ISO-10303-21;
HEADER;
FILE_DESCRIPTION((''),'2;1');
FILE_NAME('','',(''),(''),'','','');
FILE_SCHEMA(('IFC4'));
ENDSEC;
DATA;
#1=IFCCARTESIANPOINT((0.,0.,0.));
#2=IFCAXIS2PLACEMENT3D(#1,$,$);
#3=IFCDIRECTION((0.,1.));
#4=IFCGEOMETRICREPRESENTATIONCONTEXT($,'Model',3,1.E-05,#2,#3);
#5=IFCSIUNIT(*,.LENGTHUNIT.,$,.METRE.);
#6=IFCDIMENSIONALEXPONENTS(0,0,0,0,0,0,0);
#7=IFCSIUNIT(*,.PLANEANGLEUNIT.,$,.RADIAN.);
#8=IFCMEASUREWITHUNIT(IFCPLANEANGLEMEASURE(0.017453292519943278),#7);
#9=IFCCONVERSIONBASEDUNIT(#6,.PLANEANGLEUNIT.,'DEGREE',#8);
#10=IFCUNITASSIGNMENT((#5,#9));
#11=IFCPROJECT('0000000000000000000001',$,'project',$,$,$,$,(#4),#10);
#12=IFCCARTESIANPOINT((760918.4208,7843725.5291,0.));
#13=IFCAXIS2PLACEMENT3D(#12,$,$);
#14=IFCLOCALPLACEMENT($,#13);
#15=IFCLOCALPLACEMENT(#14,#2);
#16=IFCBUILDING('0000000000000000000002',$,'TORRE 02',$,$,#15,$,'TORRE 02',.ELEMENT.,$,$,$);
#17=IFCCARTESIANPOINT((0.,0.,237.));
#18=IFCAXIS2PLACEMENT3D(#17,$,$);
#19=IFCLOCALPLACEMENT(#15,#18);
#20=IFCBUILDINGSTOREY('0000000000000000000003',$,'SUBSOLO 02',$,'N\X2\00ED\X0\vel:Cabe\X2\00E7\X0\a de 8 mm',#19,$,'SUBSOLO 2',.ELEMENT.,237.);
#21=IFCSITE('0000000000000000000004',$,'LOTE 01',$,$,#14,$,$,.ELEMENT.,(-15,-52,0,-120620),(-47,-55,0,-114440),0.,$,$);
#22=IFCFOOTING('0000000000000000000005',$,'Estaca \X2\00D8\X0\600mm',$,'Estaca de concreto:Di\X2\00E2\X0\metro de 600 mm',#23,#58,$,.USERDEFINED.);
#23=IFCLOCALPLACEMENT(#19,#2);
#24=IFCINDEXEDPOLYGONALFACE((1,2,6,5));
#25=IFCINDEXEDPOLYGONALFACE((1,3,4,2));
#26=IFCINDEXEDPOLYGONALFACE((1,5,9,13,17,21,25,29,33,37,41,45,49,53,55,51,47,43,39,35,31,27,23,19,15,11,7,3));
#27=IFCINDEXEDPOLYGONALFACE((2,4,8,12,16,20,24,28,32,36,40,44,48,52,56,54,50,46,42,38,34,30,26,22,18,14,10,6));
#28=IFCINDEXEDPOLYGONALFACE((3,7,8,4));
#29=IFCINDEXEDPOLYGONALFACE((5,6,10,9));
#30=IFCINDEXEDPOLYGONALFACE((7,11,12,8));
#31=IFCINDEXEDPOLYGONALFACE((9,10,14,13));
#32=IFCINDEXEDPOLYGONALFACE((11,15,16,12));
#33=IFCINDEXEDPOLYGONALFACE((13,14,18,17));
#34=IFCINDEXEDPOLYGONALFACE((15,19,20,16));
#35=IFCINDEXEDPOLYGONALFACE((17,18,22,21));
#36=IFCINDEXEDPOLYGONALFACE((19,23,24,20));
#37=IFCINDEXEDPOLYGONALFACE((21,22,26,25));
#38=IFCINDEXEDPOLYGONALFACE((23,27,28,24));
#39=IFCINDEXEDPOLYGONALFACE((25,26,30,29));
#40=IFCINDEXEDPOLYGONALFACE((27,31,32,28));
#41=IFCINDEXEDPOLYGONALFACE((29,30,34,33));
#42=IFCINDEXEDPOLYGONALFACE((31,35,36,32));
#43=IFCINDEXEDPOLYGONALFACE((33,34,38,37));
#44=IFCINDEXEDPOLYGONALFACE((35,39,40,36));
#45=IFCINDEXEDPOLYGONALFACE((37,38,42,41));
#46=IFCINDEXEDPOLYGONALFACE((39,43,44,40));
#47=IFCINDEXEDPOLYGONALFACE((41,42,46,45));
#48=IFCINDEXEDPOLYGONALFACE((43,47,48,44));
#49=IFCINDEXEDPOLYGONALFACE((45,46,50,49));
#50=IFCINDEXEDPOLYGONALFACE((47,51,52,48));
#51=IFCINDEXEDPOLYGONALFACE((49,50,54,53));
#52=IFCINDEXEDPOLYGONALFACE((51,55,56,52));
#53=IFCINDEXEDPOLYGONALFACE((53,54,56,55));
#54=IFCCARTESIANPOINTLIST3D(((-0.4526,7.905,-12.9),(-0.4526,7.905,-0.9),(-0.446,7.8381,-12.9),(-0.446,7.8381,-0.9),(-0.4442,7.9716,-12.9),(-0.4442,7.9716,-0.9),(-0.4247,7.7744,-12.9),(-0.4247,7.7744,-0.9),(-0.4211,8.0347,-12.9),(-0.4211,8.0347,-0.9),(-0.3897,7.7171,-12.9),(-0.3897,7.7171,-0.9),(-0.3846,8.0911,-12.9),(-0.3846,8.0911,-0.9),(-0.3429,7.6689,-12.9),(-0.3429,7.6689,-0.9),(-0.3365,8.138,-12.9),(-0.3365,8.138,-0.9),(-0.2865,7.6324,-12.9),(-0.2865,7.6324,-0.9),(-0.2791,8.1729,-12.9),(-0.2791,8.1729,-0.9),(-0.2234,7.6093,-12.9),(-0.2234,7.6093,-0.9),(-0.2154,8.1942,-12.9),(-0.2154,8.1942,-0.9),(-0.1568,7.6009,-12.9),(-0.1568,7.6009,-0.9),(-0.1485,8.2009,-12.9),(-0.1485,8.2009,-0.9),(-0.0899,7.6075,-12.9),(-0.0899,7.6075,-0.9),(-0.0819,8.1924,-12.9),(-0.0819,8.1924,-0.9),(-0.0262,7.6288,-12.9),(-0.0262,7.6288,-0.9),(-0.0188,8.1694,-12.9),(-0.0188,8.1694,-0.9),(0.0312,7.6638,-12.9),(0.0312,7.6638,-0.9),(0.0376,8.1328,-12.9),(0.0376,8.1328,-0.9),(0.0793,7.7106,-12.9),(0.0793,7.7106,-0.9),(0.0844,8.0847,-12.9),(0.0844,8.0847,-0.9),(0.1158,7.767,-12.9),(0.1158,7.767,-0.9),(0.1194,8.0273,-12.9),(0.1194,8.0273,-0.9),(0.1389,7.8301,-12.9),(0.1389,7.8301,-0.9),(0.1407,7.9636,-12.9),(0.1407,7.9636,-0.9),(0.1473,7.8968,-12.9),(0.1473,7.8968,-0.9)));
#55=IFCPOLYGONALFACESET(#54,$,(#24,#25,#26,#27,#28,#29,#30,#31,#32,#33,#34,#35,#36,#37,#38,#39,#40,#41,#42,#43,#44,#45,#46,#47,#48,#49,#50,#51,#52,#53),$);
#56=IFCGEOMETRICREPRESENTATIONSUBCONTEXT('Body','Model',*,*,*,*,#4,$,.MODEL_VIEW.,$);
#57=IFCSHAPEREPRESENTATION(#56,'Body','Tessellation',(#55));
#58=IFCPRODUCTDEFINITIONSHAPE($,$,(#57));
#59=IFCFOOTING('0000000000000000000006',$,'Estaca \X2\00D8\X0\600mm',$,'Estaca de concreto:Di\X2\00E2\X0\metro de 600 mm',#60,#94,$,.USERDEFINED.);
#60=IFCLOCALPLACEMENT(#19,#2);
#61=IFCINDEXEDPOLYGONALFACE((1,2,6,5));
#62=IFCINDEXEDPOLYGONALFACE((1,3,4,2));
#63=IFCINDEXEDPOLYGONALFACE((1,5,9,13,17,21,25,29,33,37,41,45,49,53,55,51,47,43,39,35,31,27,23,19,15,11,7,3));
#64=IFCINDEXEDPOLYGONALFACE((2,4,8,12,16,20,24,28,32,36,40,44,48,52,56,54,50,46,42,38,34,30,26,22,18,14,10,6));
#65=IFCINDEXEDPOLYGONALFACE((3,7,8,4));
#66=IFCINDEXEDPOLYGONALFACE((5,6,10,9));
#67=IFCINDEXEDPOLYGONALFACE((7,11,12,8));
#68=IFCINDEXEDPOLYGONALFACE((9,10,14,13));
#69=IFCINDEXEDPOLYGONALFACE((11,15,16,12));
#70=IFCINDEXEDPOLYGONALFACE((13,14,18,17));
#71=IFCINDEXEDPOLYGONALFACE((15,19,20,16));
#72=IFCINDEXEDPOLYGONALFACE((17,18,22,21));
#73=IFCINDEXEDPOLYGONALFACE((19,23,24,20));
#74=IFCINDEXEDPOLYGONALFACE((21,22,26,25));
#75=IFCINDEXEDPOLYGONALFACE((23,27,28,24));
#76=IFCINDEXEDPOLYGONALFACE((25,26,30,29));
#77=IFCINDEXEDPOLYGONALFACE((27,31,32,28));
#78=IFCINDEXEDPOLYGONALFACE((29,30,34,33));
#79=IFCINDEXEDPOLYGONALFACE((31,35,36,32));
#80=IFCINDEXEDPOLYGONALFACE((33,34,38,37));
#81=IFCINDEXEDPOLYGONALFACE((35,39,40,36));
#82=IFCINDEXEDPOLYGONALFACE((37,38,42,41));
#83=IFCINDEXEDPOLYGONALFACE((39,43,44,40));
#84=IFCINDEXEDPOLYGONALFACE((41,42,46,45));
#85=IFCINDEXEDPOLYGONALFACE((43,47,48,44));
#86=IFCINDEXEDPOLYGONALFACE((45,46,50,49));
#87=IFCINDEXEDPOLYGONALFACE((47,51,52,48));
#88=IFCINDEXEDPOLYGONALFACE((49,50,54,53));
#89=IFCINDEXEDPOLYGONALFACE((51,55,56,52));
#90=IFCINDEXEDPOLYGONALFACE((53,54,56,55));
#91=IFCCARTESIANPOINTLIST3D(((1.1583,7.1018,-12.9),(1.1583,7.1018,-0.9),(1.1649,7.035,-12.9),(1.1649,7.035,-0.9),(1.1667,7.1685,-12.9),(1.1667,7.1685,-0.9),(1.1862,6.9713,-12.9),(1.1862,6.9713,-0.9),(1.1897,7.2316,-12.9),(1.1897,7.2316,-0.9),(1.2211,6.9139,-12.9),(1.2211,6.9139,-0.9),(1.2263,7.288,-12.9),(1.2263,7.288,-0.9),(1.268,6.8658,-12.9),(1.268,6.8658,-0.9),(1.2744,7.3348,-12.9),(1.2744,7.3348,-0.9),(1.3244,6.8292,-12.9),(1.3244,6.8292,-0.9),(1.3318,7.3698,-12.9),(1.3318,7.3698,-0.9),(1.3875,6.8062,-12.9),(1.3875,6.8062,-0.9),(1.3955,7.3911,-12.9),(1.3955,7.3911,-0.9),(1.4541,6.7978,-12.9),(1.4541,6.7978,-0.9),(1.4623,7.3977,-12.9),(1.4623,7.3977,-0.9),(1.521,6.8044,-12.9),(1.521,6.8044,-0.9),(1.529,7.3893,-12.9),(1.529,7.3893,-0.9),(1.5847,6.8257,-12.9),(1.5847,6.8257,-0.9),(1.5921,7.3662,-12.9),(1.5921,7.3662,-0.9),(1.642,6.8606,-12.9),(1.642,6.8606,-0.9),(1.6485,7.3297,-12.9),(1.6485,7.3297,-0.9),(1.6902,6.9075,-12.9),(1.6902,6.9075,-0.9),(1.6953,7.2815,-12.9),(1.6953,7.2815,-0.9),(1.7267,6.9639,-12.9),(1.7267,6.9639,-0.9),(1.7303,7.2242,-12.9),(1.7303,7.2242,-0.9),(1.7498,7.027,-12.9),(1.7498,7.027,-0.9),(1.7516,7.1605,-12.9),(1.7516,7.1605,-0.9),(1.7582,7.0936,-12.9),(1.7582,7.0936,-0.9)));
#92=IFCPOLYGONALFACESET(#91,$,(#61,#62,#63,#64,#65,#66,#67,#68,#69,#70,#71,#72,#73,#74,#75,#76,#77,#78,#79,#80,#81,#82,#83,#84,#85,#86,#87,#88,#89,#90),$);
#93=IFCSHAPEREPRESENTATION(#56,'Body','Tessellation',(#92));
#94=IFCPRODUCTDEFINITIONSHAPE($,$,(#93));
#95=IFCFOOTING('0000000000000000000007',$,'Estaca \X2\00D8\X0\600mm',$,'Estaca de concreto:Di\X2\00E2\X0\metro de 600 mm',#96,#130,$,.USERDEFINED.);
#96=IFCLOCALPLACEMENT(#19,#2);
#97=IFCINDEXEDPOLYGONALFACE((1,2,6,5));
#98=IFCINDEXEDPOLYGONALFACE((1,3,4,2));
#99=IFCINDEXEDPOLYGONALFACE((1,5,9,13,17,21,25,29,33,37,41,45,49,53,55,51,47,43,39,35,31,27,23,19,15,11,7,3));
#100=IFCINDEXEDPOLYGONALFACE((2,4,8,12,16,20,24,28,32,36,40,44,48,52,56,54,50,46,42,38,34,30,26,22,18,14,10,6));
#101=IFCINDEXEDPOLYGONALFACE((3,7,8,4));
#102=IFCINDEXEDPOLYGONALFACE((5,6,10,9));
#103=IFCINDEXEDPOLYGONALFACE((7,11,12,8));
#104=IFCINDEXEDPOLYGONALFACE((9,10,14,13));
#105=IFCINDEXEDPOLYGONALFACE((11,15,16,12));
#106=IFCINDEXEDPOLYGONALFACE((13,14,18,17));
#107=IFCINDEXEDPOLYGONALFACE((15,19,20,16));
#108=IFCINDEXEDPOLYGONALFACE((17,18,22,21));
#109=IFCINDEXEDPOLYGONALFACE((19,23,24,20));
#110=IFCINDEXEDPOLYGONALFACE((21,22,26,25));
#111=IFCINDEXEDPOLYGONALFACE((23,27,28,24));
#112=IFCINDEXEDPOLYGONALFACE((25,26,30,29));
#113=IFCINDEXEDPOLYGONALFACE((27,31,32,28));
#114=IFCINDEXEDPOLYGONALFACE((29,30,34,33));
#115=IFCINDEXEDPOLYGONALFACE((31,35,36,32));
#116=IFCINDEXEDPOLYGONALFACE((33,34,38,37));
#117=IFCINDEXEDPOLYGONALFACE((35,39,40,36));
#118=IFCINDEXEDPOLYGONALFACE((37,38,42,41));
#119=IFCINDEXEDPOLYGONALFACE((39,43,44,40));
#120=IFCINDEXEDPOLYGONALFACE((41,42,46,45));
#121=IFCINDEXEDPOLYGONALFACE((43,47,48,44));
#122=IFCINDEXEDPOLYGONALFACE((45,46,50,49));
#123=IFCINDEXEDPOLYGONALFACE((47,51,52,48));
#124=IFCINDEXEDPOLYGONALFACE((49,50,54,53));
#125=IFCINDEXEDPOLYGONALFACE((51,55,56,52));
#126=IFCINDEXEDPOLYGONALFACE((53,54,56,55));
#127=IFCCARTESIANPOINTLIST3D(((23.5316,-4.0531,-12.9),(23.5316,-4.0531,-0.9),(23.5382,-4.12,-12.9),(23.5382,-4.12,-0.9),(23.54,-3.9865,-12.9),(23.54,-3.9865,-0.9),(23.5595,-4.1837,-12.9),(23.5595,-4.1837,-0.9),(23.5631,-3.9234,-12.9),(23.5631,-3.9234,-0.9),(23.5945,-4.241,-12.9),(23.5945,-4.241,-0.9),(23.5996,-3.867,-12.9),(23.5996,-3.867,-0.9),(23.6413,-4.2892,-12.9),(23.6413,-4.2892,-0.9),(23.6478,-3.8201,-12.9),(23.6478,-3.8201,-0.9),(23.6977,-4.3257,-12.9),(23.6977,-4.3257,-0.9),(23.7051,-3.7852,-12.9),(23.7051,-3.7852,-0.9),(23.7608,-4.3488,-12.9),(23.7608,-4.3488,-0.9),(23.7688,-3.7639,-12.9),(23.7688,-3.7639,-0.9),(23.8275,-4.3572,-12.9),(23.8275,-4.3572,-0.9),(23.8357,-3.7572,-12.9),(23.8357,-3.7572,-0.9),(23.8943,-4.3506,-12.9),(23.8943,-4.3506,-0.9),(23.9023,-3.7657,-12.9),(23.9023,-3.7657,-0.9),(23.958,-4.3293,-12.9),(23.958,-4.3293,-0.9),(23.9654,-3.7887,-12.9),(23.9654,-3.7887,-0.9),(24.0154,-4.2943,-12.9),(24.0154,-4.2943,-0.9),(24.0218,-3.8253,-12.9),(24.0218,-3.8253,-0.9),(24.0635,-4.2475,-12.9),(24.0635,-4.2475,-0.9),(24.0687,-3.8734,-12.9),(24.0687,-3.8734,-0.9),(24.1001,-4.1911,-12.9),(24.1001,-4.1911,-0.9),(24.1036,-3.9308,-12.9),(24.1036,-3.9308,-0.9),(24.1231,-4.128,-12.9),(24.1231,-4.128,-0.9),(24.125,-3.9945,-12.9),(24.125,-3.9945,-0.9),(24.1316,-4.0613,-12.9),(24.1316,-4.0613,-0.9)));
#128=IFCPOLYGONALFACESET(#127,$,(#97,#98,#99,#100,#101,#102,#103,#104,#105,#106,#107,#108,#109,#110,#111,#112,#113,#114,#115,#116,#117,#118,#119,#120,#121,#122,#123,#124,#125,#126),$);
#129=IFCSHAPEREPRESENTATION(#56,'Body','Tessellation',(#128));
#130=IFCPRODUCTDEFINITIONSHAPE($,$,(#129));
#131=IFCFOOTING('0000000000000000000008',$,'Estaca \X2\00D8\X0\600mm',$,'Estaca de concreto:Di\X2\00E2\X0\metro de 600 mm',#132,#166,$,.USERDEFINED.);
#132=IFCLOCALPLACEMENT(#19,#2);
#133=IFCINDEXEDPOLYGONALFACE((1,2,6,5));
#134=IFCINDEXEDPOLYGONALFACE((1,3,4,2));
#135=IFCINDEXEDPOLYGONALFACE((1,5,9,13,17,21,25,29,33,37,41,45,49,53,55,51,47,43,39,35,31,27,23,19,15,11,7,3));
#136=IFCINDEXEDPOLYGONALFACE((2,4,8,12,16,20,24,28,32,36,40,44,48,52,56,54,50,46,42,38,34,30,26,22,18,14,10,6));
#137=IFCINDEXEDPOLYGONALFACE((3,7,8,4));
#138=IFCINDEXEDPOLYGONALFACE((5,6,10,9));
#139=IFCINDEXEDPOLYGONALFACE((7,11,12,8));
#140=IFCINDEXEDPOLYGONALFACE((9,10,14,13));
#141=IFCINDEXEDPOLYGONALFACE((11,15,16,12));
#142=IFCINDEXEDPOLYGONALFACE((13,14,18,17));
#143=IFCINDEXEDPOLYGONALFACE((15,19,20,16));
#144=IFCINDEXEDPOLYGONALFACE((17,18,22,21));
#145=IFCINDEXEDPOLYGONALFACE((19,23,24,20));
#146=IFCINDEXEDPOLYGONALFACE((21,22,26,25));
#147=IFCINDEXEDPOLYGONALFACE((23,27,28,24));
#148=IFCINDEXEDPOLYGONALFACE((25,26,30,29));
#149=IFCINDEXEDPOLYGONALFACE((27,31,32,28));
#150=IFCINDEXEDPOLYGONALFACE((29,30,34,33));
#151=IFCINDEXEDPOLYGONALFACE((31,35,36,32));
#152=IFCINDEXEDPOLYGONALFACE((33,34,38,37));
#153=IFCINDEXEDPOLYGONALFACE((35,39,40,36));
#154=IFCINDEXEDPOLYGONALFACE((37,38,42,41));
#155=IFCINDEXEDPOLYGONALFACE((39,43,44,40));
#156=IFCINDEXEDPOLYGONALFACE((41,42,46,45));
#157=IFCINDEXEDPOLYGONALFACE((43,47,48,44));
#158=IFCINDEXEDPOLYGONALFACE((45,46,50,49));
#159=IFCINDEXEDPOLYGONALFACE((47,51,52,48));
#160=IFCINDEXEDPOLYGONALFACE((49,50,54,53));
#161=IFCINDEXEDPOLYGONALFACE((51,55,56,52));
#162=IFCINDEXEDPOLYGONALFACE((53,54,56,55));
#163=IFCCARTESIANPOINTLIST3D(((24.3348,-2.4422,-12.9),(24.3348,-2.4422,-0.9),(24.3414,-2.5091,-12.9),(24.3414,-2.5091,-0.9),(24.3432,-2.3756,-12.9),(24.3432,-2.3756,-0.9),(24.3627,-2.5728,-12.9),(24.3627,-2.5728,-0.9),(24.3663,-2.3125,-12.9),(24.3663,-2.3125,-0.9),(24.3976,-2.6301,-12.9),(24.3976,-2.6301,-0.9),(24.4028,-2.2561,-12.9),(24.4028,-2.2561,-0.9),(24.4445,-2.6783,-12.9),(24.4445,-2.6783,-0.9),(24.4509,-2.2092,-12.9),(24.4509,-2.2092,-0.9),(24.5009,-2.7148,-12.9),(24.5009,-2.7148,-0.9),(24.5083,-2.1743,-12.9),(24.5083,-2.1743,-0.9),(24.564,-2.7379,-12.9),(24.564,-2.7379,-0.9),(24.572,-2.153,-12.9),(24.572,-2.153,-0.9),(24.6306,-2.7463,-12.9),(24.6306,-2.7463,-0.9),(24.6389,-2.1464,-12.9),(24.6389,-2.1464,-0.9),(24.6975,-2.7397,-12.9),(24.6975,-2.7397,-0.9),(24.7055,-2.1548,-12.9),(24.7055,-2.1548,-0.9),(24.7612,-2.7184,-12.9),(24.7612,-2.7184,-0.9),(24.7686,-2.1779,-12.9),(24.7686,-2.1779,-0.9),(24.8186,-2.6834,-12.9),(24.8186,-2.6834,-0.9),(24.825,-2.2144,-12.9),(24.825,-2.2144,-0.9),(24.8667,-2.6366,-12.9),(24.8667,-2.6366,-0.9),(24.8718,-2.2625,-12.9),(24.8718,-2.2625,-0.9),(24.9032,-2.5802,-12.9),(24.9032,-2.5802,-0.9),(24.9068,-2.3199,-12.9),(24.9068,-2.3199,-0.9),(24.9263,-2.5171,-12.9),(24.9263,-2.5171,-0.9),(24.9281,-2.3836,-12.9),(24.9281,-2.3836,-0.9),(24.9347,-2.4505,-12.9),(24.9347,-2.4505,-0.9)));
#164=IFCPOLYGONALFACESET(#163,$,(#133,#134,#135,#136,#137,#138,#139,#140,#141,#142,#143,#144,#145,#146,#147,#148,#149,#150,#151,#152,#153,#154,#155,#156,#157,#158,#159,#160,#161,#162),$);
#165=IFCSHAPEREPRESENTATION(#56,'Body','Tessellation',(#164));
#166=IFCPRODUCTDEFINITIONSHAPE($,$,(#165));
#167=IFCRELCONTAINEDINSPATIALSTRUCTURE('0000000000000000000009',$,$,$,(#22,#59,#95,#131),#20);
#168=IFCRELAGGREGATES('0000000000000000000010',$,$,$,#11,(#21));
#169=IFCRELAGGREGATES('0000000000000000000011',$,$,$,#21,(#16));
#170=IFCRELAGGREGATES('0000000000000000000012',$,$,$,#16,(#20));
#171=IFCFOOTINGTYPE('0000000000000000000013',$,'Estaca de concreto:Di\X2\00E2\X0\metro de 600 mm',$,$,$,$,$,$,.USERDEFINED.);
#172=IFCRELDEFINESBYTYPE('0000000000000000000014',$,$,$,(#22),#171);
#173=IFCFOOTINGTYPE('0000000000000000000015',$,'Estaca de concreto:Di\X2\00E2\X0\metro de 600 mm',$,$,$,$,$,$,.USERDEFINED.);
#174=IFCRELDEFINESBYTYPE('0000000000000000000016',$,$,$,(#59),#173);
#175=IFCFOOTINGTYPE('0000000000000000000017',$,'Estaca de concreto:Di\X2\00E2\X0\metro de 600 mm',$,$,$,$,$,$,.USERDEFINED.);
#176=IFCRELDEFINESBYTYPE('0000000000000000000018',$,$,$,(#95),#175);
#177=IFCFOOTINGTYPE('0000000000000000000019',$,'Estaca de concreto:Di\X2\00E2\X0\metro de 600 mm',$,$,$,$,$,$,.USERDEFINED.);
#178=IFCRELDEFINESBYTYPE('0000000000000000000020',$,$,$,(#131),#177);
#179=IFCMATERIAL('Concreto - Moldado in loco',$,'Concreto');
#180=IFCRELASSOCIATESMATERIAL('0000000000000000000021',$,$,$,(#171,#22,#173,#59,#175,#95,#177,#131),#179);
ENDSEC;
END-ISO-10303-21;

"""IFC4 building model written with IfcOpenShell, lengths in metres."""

from ifc_helpers import new_model, entity, si_unit, converted_unit, direction, frame, origin, place, context, subcontext, project, spatial, arc, indexed_curve, outline, extrude, source, transform, mapped, material, type_object, type_shapes, element, save


model = new_model("IFC4")

# Units and contexts
model_context = context("Model", 3, precision=1e-05, world=origin(), true_north=direction((0.0, 1.0)))
body_context = subcontext(model_context, "Body", "Model", "MODEL_VIEW")
ifc_project = project(units=[si_unit("LENGTHUNIT", "METRE"), converted_unit("PLANEANGLEUNIT", "DEGREE", entity("IfcPlaneAngleMeasure", 0.017453292519943278), si_unit("PLANEANGLEUNIT", "RADIAN"), dimensions=[0, 0, 0, 0, 0, 0, 0])], contexts=[model_context])

# Site, building, storey
site_placement = place(None, frame((760918.4208, 7843725.5291, 0.0)))
site = spatial("IfcSite", under=ifc_project, at=site_placement, Name="LOTE 01", CompositionType="ELEMENT", RefLatitude=(-15, -52, 0, -120620), RefLongitude=(-47, -55, 0, -114440), RefElevation=0.0)
building_placement = place(site_placement, origin())
building = spatial("IfcBuilding", under=site, at=building_placement, Name="TORRE 02", LongName="TORRE 02", CompositionType="ELEMENT")
storey_placement = place(building_placement, frame((0.0, 0.0, 237.0)))
storey = spatial("IfcBuildingStorey", under=building, at=storey_placement, Name="SUBSOLO 02", ObjectType="Nível:Cabeça de 8 mm", LongName="SUBSOLO 2", CompositionType="ELEMENT", Elevation=237.0)

# Footings
ifc_material_1 = material(Name="Concreto - Moldado in loco", Category="Concreto")
footing_type_1 = type_object("IfcFootingType", Name="Estaca de concreto:Diâmetro de 600 mm", PredefinedType="USERDEFINED", material=ifc_material_1)
shared_shape_1 = source(origin(), body_context, "Body", "SweptSolid", [
    extrude(outline(indexed_curve([(-0.3, 0.0), (0.0, -0.3), (0.3, 0.0), (0.0, 0.3)], segments=[arc(1, 2, 3), arc(3, 4, 1)], self_intersect=False)), frame((-0.1527, 7.9009, -12.0), z_axis=(0.0, 0.0, 1.0), x_axis=(0.894934, -0.446198, 0.0)), (0.0, 0.0, 1.0), 12.0),
])
type_shapes(footing_type_1, [shared_shape_1])
placement = place(building_placement, frame((0.0, 0.0, 237.0)))
footing_1_placement = place(placement, frame((0.0, 0.0, -0.9)))
element("IfcFooting", 1, at=footing_1_placement, inside=storey, type_object=footing_type_1, material=ifc_material_1, Name="Estaca Ø600mm", ObjectType="Estaca de concreto:Diâmetro de 600 mm", PredefinedType="USERDEFINED", context=body_context, shape_type="MappedRepresentation", body=[
    mapped(shared_shape_1, transform((0.0, 0.0, 0.0), scale=1.0)),
])
footing_type_2 = type_object("IfcFootingType", Name="Estaca de concreto:Diâmetro de 600 mm", PredefinedType="USERDEFINED", material=ifc_material_1)
shared_shape_2 = source(origin(), body_context, "Body", "SweptSolid", [
    extrude(outline(indexed_curve([(-0.3, 0.0), (0.0, -0.3), (0.3, 0.0), (0.0, 0.3)], segments=[arc(1, 2, 3), arc(3, 4, 1)], self_intersect=False)), frame((1.4582, 7.0977, -12.0), z_axis=(0.0, 0.0, 1.0), x_axis=(0.894934, -0.446198, 0.0)), (0.0, 0.0, 1.0), 12.0),
])
type_shapes(footing_type_2, [shared_shape_2])
footing_2_placement = place(placement, frame((0.0, 0.0, -0.9)))
element("IfcFooting", 2, at=footing_2_placement, inside=storey, type_object=footing_type_2, material=ifc_material_1, Name="Estaca Ø600mm", ObjectType="Estaca de concreto:Diâmetro de 600 mm", PredefinedType="USERDEFINED", context=body_context, shape_type="MappedRepresentation", body=[
    mapped(shared_shape_2, transform((0.0, 0.0, 0.0), scale=1.0)),
])
footing_type_3 = type_object("IfcFootingType", Name="Estaca de concreto:Diâmetro de 600 mm", PredefinedType="USERDEFINED", material=ifc_material_1)
shared_shape_3 = source(origin(), body_context, "Body", "SweptSolid", [
    extrude(outline(indexed_curve([(-0.3, 0.0), (0.0, -0.3), (0.3, 0.0), (0.0, 0.3)], segments=[arc(1, 2, 3), arc(3, 4, 1)], self_intersect=False)), frame((23.8316, -4.0572, -12.0), z_axis=(0.0, 0.0, 1.0), x_axis=(0.894934, -0.446198, 0.0)), (0.0, 0.0, 1.0), 12.0),
])
type_shapes(footing_type_3, [shared_shape_3])
footing_3_placement = place(placement, frame((0.0, 0.0, -0.9)))
element("IfcFooting", 3, at=footing_3_placement, inside=storey, type_object=footing_type_3, material=ifc_material_1, Name="Estaca Ø600mm", ObjectType="Estaca de concreto:Diâmetro de 600 mm", PredefinedType="USERDEFINED", context=body_context, shape_type="MappedRepresentation", body=[
    mapped(shared_shape_3, transform((0.0, 0.0, 0.0), scale=1.0)),
])
footing_type_4 = type_object("IfcFootingType", Name="Estaca de concreto:Diâmetro de 600 mm", PredefinedType="USERDEFINED", material=ifc_material_1)
shared_shape_4 = source(origin(), body_context, "Body", "SweptSolid", [
    extrude(outline(indexed_curve([(-0.3, 0.0), (0.0, -0.3), (0.3, 0.0), (0.0, 0.3)], segments=[arc(1, 2, 3), arc(3, 4, 1)], self_intersect=False)), frame((24.6347, -2.4463, -12.0), z_axis=(0.0, 0.0, 1.0), x_axis=(0.894934, -0.446198, 0.0)), (0.0, 0.0, 1.0), 12.0),
])
type_shapes(footing_type_4, [shared_shape_4])
footing_4_placement = place(placement, frame((0.0, 0.0, -0.9)))
element("IfcFooting", 4, at=footing_4_placement, inside=storey, type_object=footing_type_4, material=ifc_material_1, Name="Estaca Ø600mm", ObjectType="Estaca de concreto:Diâmetro de 600 mm", PredefinedType="USERDEFINED", context=body_context, shape_type="MappedRepresentation", body=[
    mapped(shared_shape_4, transform((0.0, 0.0, 0.0), scale=1.0)),
])

save(model, "model.ifc")
